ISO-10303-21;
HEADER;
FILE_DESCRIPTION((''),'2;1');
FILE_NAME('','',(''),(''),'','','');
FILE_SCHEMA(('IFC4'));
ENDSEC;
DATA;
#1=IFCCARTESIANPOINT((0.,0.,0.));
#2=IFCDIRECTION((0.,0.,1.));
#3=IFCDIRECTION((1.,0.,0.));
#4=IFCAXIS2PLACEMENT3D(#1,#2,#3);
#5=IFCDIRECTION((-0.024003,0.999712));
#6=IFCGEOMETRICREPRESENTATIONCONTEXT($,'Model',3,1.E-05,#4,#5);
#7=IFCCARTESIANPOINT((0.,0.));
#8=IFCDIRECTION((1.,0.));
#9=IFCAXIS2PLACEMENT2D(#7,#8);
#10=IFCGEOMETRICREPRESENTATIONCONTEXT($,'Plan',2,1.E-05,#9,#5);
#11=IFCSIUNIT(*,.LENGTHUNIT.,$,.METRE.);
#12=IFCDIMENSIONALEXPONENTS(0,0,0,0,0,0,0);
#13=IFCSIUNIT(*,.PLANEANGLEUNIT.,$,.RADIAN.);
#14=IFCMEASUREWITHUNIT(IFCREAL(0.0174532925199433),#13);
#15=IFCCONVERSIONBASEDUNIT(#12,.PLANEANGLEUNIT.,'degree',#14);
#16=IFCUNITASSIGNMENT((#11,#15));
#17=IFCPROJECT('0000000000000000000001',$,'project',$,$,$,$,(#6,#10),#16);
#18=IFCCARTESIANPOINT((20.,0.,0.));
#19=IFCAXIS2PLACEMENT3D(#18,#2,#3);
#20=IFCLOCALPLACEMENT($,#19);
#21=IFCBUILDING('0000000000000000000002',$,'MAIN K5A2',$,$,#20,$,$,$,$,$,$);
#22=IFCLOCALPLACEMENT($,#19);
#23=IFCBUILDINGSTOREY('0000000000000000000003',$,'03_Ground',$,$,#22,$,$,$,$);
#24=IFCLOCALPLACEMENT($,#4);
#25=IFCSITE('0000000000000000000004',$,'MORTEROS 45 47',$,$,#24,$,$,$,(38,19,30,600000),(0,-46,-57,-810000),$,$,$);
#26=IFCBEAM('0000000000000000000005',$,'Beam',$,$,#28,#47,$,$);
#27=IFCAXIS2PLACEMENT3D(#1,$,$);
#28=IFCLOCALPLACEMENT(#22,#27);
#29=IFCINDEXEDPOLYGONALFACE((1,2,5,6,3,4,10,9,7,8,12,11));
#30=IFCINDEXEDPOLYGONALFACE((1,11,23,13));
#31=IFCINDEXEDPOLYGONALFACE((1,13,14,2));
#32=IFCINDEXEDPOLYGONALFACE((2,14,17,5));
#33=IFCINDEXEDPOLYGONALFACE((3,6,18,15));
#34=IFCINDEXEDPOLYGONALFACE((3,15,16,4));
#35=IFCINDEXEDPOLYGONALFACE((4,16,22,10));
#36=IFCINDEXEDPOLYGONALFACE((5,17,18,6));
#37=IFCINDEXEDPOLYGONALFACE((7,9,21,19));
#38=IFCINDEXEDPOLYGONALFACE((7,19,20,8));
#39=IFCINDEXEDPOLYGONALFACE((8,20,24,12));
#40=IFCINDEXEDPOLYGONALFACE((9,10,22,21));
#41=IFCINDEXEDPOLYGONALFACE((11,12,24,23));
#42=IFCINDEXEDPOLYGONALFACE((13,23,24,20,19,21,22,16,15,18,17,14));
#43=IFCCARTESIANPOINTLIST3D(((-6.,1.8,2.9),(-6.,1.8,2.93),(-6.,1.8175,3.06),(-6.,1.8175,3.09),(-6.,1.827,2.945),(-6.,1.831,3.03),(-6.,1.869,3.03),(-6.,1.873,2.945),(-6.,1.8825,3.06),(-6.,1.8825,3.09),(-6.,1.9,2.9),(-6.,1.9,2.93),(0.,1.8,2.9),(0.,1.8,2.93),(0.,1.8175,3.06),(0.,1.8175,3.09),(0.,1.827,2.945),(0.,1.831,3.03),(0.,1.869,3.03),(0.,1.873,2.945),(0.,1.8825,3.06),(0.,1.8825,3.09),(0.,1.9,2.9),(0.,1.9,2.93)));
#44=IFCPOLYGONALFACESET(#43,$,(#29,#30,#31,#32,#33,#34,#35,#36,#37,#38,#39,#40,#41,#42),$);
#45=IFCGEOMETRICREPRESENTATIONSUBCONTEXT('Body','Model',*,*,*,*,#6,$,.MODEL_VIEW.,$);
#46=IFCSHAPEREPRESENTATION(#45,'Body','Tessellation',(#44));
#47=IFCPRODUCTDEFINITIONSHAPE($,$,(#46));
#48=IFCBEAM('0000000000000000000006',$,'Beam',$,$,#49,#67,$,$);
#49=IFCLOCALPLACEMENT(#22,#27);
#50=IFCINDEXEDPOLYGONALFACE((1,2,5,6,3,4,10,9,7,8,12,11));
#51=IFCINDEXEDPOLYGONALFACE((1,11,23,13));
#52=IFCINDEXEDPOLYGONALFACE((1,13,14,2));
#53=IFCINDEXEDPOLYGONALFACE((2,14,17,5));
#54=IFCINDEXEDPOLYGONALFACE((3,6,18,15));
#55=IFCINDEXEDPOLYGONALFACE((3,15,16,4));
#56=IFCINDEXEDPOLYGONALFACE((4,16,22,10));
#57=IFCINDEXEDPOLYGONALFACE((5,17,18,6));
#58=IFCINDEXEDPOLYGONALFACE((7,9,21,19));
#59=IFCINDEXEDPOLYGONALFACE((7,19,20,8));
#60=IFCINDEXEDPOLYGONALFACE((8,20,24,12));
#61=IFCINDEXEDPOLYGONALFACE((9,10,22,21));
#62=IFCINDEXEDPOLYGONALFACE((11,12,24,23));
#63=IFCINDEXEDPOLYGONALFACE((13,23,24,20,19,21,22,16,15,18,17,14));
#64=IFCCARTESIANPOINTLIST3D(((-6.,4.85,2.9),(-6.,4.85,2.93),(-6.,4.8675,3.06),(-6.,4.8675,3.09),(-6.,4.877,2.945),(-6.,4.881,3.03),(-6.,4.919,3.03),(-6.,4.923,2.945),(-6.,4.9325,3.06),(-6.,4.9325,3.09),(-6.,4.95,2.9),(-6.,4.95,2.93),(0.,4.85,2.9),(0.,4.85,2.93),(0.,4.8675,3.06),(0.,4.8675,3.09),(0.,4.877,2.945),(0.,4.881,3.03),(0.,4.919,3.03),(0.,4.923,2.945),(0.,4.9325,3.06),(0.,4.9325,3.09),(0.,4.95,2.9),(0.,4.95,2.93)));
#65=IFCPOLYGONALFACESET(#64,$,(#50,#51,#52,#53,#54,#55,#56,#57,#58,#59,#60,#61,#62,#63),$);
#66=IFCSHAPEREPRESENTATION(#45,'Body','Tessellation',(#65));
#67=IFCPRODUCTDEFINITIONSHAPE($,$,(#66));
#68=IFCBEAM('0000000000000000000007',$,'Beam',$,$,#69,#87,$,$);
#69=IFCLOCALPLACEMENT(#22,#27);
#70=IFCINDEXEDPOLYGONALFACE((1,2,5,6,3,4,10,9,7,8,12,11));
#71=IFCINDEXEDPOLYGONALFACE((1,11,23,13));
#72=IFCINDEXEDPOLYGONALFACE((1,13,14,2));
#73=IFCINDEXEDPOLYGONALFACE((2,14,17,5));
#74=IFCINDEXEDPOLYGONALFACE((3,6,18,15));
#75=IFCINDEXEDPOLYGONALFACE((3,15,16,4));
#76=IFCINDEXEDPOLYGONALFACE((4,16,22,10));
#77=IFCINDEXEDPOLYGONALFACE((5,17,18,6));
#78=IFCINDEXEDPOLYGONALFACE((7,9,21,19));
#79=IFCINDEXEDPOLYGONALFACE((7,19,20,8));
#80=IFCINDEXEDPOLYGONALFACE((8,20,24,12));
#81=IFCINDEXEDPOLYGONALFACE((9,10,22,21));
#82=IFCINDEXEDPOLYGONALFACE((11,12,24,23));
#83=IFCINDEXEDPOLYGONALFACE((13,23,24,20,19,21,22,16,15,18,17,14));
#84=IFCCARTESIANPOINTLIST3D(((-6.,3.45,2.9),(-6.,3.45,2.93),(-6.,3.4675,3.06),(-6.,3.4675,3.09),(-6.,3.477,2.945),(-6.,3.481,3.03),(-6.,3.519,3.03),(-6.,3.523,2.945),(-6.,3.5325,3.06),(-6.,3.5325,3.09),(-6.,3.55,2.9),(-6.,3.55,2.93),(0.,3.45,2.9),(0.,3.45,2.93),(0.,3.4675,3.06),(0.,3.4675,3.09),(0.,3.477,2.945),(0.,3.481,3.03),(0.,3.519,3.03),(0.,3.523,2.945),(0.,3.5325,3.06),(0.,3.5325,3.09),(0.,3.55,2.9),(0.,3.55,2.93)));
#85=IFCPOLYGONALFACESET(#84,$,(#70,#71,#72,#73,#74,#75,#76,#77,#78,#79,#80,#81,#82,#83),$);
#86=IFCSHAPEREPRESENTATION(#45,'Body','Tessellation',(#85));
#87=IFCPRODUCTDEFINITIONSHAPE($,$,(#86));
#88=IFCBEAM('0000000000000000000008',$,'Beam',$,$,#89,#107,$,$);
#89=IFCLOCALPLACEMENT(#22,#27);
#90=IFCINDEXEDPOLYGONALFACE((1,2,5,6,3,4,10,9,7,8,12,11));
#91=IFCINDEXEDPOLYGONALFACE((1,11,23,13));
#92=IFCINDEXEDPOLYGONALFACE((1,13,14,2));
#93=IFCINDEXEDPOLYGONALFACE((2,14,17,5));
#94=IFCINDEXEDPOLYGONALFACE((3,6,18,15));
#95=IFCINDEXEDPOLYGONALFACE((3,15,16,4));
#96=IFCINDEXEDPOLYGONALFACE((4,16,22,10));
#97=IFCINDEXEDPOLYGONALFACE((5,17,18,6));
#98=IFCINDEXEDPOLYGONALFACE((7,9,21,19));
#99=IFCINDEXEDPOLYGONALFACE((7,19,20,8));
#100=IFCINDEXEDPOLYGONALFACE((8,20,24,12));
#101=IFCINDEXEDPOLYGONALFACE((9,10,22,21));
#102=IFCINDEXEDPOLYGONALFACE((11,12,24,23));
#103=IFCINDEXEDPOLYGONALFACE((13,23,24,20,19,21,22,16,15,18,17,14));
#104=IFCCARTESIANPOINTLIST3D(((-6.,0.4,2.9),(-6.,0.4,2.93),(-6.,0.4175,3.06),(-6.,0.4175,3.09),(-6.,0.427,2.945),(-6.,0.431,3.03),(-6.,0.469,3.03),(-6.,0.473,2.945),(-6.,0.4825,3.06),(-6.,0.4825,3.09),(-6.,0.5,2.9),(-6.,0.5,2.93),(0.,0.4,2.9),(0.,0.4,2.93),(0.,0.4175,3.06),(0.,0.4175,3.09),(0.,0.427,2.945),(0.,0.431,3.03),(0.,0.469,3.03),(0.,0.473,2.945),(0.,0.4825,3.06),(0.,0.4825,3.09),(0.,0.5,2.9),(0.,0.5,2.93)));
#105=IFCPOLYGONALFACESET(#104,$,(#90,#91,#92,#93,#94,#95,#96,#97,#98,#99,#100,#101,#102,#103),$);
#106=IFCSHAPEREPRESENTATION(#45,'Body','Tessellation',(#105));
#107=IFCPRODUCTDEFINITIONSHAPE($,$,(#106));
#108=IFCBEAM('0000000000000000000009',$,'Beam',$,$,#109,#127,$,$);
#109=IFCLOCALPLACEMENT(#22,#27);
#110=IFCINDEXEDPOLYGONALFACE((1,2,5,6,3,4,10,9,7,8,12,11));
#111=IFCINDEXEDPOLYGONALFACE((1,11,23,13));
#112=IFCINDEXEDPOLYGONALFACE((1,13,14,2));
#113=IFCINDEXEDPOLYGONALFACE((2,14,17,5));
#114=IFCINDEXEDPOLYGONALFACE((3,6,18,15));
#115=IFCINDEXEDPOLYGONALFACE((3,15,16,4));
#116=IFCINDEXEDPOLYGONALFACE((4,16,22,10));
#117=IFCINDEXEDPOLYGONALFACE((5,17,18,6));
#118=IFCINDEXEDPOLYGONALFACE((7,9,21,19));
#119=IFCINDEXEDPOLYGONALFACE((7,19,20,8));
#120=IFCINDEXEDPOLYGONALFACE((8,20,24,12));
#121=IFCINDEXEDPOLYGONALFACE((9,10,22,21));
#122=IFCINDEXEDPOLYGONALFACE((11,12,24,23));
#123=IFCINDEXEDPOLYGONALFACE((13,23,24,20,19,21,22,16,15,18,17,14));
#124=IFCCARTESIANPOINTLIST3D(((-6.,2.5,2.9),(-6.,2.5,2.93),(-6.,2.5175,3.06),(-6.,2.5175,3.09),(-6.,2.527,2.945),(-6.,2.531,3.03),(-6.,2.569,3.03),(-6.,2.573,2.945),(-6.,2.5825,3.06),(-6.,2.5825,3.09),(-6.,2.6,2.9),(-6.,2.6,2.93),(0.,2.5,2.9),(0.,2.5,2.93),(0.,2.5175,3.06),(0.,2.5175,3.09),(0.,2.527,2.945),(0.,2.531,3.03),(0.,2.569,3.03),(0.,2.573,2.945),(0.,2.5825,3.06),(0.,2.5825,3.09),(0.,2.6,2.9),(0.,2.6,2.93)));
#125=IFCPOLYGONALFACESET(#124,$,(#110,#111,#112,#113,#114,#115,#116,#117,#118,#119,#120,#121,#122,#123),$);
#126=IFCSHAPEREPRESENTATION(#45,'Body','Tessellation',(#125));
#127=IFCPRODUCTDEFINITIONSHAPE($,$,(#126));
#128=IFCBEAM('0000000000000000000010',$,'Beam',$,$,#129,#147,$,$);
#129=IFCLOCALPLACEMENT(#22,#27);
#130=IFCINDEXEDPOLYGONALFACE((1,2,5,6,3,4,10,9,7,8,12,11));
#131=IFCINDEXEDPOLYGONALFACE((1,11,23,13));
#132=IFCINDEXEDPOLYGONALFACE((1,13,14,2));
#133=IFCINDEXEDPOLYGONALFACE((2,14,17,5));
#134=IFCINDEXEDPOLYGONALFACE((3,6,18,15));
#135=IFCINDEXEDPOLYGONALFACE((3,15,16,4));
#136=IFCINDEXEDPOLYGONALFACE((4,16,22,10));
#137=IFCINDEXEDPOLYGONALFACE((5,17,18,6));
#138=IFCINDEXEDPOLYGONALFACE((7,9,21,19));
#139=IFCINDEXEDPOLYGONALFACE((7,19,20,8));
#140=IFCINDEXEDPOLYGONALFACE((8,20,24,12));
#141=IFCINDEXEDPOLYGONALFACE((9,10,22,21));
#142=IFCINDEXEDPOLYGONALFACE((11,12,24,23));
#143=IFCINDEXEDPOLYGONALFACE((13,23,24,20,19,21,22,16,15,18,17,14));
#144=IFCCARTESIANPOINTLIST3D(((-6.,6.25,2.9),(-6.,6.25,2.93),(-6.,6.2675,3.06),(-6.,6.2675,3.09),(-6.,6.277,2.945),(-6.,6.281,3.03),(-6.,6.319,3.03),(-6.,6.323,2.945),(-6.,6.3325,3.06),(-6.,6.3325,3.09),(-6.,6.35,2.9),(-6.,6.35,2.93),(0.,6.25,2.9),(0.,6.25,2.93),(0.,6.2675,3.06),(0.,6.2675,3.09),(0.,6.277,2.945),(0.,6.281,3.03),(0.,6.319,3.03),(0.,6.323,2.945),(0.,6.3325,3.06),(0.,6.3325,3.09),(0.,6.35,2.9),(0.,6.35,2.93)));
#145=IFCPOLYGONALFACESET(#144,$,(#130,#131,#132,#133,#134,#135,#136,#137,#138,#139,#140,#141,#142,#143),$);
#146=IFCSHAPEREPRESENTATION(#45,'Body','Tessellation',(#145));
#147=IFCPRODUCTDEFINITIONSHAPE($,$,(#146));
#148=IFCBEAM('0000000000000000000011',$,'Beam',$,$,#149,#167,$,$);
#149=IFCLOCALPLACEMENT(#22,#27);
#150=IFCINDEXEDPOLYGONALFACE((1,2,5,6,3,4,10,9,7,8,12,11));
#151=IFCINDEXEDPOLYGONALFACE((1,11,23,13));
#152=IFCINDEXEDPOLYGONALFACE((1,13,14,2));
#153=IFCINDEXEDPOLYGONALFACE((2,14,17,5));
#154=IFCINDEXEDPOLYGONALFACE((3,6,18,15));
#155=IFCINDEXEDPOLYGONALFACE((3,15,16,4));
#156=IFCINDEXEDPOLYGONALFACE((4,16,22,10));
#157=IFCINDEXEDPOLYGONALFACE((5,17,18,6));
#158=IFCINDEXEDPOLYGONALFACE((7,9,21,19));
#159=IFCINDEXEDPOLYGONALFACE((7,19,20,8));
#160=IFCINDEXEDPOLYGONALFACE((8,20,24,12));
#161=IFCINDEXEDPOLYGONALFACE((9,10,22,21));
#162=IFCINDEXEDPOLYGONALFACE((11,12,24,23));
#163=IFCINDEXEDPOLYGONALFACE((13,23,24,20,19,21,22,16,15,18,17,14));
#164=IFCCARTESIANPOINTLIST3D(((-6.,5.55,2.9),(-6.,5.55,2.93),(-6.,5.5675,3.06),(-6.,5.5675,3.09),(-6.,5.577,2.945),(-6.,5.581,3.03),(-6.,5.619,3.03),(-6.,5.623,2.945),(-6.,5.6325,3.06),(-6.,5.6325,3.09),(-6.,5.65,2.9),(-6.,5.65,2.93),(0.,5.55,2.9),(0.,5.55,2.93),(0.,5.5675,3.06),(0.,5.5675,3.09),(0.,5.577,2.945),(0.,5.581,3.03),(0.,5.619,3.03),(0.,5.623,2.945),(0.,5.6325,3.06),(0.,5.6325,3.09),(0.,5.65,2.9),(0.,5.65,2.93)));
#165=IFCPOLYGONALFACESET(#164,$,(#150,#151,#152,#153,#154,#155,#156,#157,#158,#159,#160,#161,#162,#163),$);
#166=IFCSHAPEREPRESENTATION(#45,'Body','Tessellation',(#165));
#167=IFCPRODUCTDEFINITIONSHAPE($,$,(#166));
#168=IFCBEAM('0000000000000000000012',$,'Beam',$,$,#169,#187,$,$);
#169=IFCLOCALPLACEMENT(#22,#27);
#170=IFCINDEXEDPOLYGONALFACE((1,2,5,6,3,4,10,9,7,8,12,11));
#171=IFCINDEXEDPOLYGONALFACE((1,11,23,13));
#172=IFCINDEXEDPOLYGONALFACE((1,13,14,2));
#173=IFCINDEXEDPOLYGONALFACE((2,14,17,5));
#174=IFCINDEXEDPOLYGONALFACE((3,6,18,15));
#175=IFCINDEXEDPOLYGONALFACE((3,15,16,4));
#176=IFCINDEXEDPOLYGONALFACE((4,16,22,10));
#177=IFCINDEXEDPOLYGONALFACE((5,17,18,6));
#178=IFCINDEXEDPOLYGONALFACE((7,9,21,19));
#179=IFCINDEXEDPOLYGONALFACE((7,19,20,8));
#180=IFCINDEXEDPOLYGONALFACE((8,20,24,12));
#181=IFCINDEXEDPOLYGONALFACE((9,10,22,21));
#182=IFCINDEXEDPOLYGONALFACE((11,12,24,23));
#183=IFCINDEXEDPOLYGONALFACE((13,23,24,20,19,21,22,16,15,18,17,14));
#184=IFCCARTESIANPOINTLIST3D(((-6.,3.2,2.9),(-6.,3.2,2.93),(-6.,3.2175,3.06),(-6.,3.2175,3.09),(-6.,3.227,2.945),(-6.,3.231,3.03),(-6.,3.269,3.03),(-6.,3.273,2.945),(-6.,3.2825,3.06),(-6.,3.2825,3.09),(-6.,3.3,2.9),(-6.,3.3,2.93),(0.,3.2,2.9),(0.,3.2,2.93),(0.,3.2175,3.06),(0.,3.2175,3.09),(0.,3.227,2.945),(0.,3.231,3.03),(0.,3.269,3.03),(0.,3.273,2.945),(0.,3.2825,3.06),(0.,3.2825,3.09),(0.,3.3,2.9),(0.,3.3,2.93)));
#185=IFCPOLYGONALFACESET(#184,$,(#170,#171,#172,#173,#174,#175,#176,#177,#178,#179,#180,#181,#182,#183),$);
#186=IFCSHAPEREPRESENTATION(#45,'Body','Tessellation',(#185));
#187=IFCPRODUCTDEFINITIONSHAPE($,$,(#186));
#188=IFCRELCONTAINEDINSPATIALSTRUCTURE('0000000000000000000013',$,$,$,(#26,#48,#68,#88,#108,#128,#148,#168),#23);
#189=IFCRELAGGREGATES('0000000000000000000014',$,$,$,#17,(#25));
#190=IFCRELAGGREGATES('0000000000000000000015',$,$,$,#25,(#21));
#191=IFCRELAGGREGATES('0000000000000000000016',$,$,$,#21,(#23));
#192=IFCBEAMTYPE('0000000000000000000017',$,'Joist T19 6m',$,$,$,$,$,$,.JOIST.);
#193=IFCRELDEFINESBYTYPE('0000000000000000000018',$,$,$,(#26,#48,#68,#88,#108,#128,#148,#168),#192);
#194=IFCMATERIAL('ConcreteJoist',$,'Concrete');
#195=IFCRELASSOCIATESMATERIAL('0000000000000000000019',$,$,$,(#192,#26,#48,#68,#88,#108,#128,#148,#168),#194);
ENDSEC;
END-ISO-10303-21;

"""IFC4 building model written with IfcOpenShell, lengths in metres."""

from ifc_helpers import new_model, entity, si_unit, converted_unit, direction, frame, origin_with_axes, origin_2d_with_axis, place, context, subcontext, project, spatial, indexed_curve, outline, extrude, material, material_profile, profile_set, profile_usage, type_object, element, save


model = new_model("IFC4")

# Units and contexts
model_context = context("Model", 3, precision=1e-05, world=origin_with_axes(), true_north=direction((-0.024003, 0.999712)))
plan_context = context("Plan", 2, precision=1e-05, world=origin_2d_with_axis(), true_north=direction((-0.024003, 0.999712)))
body_context_1 = subcontext(model_context, "Body", "Model", "MODEL_VIEW")
ifc_project = project(units=[si_unit("LENGTHUNIT", "METRE"), converted_unit("PLANEANGLEUNIT", "degree", entity("IfcReal", 0.0174532925199433), si_unit("PLANEANGLEUNIT", "RADIAN"), dimensions=[0, 0, 0, 0, 0, 0, 0])], contexts=[model_context, plan_context])

# Site, building, storey
site_placement = place(None, origin_with_axes())
site = spatial("IfcSite", under=ifc_project, at=site_placement, Name="MORTEROS 45 47", RefLatitude=(38, 19, 30, 600000), RefLongitude=(0, -46, -57, -810000))
building_placement = place(None, frame((20.0, 0.0, 0.0), z_axis=(0.0, 0.0, 1.0), x_axis=(1.0, 0.0, 0.0)))
building = spatial("IfcBuilding", under=site, at=building_placement, Name="MAIN K5A2")
storey_placement = place(None, frame((20.0, 0.0, 0.0), z_axis=(0.0, 0.0, 1.0), x_axis=(1.0, 0.0, 0.0)))
storey = spatial("IfcBuildingStorey", under=building, at=storey_placement, Name="03_Ground")

# Beams
ifc_material = material(Name="ConcreteJoist", Category="Concrete")
ifc_material_profile = material_profile(ifc_material, outline(indexed_curve([(0.019, 0.13), (0.023, 0.045), (0.05, 0.03), (0.05, 0.0), (-0.05, 0.0), (-0.05, 0.03), (-0.023, 0.045), (-0.019, 0.13), (-0.0325, 0.16), (-0.0325, 0.19), (0.0325, 0.19), (0.0325, 0.16), (0.019, 0.13)])))
ifc_profile_set = profile_set([ifc_material_profile], Name="JoistmaterialProfile")
ifc_profile_usage_1 = profile_usage(ifc_profile_set)
beam_type = type_object("IfcBeamType", Name="Joist T19 6m", PredefinedType="JOIST", material=ifc_profile_set)
beam_1_placement = place(None, frame((14.0, 1.85, 2.9), z_axis=(1.0, 0.0, 0.0), x_axis=(0.0, 1.0, 0.0)))
element("IfcBeam", 1, at=beam_1_placement, inside=storey, type_object=beam_type, material=ifc_profile_usage_1, Name="Beam", context=body_context_1, shape_type="SweptSolid", body=[
    extrude(outline(indexed_curve([(0.019, 0.13), (0.023, 0.045), (0.05, 0.03), (0.05, 0.0), (-0.05, 0.0), (-0.05, 0.03), (-0.023, 0.045), (-0.019, 0.13), (-0.0325, 0.16), (-0.0325, 0.19), (0.0325, 0.19), (0.0325, 0.16), (0.019, 0.13)])), origin_with_axes(), (0.0, 0.0, 1.0), 6.0),
])
ifc_profile_usage_2 = profile_usage(ifc_profile_set)
beam_2_placement = place(None, frame((14.0, 4.9, 2.9), z_axis=(1.0, 0.0, 0.0), x_axis=(0.0, 1.0, 0.0)))
element("IfcBeam", 2, at=beam_2_placement, inside=storey, type_object=beam_type, material=ifc_profile_usage_2, Name="Beam", context=body_context_1, shape_type="SweptSolid", body=[
    extrude(outline(indexed_curve([(0.019, 0.13), (0.023, 0.045), (0.05, 0.03), (0.05, 0.0), (-0.05, 0.0), (-0.05, 0.03), (-0.023, 0.045), (-0.019, 0.13), (-0.0325, 0.16), (-0.0325, 0.19), (0.0325, 0.19), (0.0325, 0.16), (0.019, 0.13)])), origin_with_axes(), (0.0, 0.0, 1.0), 6.0),
])
ifc_profile_usage_3 = profile_usage(ifc_profile_set)
beam_3_placement = place(None, frame((14.0, 3.5, 2.9), z_axis=(1.0, 0.0, 0.0), x_axis=(0.0, 1.0, 0.0)))
element("IfcBeam", 3, at=beam_3_placement, inside=storey, type_object=beam_type, material=ifc_profile_usage_3, Name="Beam", context=body_context_1, shape_type="SweptSolid", body=[
    extrude(outline(indexed_curve([(0.019, 0.13), (0.023, 0.045), (0.05, 0.03), (0.05, 0.0), (-0.05, 0.0), (-0.05, 0.03), (-0.023, 0.045), (-0.019, 0.13), (-0.0325, 0.16), (-0.0325, 0.19), (0.0325, 0.19), (0.0325, 0.16), (0.019, 0.13)])), origin_with_axes(), (0.0, 0.0, 1.0), 6.0),
])
ifc_profile_usage_4 = profile_usage(ifc_profile_set)
beam_4_placement = place(None, frame((14.0, 0.45, 2.9), z_axis=(1.0, 0.0, 0.0), x_axis=(0.0, 1.0, 0.0)))
element("IfcBeam", 4, at=beam_4_placement, inside=storey, type_object=beam_type, material=ifc_profile_usage_4, Name="Beam", context=body_context_1, shape_type="SweptSolid", body=[
    extrude(outline(indexed_curve([(0.019, 0.13), (0.023, 0.045), (0.05, 0.03), (0.05, 0.0), (-0.05, 0.0), (-0.05, 0.03), (-0.023, 0.045), (-0.019, 0.13), (-0.0325, 0.16), (-0.0325, 0.19), (0.0325, 0.19), (0.0325, 0.16), (0.019, 0.13)])), origin_with_axes(), (0.0, 0.0, 1.0), 6.0),
])
ifc_profile_usage_5 = profile_usage(ifc_profile_set)
beam_5_placement = place(None, frame((14.0, 2.55, 2.9), z_axis=(1.0, 0.0, 0.0), x_axis=(0.0, 1.0, 0.0)))
element("IfcBeam", 5, at=beam_5_placement, inside=storey, type_object=beam_type, material=ifc_profile_usage_5, Name="Beam", context=body_context_1, shape_type="SweptSolid", body=[
    extrude(outline(indexed_curve([(0.019, 0.13), (0.023, 0.045), (0.05, 0.03), (0.05, 0.0), (-0.05, 0.0), (-0.05, 0.03), (-0.023, 0.045), (-0.019, 0.13), (-0.0325, 0.16), (-0.0325, 0.19), (0.0325, 0.19), (0.0325, 0.16), (0.019, 0.13)])), origin_with_axes(), (0.0, 0.0, 1.0), 6.0),
])
ifc_profile_usage_6 = profile_usage(ifc_profile_set)
beam_6_placement = place(None, frame((14.0, 6.3, 2.9), z_axis=(1.0, 0.0, 0.0), x_axis=(0.0, 1.0, 0.0)))
element("IfcBeam", 6, at=beam_6_placement, inside=storey, type_object=beam_type, material=ifc_profile_usage_6, Name="Beam", context=body_context_1, shape_type="SweptSolid", body=[
    extrude(outline(indexed_curve([(0.019, 0.13), (0.023, 0.045), (0.05, 0.03), (0.05, 0.0), (-0.05, 0.0), (-0.05, 0.03), (-0.023, 0.045), (-0.019, 0.13), (-0.0325, 0.16), (-0.0325, 0.19), (0.0325, 0.19), (0.0325, 0.16), (0.019, 0.13)])), origin_with_axes(), (0.0, 0.0, 1.0), 6.0),
])
ifc_profile_usage_7 = profile_usage(ifc_profile_set)
beam_7_placement = place(None, frame((14.0, 5.6, 2.9), z_axis=(1.0, 0.0, 0.0), x_axis=(0.0, 1.0, 0.0)))
element("IfcBeam", 7, at=beam_7_placement, inside=storey, type_object=beam_type, material=ifc_profile_usage_7, Name="Beam", context=body_context_1, shape_type="SweptSolid", body=[
    extrude(outline(indexed_curve([(0.019, 0.13), (0.023, 0.045), (0.05, 0.03), (0.05, 0.0), (-0.05, 0.0), (-0.05, 0.03), (-0.023, 0.045), (-0.019, 0.13), (-0.0325, 0.16), (-0.0325, 0.19), (0.0325, 0.19), (0.0325, 0.16), (0.019, 0.13)])), origin_with_axes(), (0.0, 0.0, 1.0), 6.0),
])
ifc_profile_usage_8 = profile_usage(ifc_profile_set)
beam_8_placement = place(None, frame((14.0, 3.25, 2.9), z_axis=(1.0, 0.0, 0.0), x_axis=(0.0, 1.0, 0.0)))
element("IfcBeam", 8, at=beam_8_placement, inside=storey, type_object=beam_type, material=ifc_profile_usage_8, Name="Beam", context=body_context_1, shape_type="SweptSolid", body=[
    extrude(outline(indexed_curve([(0.019, 0.13), (0.023, 0.045), (0.05, 0.03), (0.05, 0.0), (-0.05, 0.0), (-0.05, 0.03), (-0.023, 0.045), (-0.019, 0.13), (-0.0325, 0.16), (-0.0325, 0.19), (0.0325, 0.19), (0.0325, 0.16), (0.019, 0.13)])), origin_with_axes(), (0.0, 0.0, 1.0), 6.0),
])

save(model, "model.ifc")
